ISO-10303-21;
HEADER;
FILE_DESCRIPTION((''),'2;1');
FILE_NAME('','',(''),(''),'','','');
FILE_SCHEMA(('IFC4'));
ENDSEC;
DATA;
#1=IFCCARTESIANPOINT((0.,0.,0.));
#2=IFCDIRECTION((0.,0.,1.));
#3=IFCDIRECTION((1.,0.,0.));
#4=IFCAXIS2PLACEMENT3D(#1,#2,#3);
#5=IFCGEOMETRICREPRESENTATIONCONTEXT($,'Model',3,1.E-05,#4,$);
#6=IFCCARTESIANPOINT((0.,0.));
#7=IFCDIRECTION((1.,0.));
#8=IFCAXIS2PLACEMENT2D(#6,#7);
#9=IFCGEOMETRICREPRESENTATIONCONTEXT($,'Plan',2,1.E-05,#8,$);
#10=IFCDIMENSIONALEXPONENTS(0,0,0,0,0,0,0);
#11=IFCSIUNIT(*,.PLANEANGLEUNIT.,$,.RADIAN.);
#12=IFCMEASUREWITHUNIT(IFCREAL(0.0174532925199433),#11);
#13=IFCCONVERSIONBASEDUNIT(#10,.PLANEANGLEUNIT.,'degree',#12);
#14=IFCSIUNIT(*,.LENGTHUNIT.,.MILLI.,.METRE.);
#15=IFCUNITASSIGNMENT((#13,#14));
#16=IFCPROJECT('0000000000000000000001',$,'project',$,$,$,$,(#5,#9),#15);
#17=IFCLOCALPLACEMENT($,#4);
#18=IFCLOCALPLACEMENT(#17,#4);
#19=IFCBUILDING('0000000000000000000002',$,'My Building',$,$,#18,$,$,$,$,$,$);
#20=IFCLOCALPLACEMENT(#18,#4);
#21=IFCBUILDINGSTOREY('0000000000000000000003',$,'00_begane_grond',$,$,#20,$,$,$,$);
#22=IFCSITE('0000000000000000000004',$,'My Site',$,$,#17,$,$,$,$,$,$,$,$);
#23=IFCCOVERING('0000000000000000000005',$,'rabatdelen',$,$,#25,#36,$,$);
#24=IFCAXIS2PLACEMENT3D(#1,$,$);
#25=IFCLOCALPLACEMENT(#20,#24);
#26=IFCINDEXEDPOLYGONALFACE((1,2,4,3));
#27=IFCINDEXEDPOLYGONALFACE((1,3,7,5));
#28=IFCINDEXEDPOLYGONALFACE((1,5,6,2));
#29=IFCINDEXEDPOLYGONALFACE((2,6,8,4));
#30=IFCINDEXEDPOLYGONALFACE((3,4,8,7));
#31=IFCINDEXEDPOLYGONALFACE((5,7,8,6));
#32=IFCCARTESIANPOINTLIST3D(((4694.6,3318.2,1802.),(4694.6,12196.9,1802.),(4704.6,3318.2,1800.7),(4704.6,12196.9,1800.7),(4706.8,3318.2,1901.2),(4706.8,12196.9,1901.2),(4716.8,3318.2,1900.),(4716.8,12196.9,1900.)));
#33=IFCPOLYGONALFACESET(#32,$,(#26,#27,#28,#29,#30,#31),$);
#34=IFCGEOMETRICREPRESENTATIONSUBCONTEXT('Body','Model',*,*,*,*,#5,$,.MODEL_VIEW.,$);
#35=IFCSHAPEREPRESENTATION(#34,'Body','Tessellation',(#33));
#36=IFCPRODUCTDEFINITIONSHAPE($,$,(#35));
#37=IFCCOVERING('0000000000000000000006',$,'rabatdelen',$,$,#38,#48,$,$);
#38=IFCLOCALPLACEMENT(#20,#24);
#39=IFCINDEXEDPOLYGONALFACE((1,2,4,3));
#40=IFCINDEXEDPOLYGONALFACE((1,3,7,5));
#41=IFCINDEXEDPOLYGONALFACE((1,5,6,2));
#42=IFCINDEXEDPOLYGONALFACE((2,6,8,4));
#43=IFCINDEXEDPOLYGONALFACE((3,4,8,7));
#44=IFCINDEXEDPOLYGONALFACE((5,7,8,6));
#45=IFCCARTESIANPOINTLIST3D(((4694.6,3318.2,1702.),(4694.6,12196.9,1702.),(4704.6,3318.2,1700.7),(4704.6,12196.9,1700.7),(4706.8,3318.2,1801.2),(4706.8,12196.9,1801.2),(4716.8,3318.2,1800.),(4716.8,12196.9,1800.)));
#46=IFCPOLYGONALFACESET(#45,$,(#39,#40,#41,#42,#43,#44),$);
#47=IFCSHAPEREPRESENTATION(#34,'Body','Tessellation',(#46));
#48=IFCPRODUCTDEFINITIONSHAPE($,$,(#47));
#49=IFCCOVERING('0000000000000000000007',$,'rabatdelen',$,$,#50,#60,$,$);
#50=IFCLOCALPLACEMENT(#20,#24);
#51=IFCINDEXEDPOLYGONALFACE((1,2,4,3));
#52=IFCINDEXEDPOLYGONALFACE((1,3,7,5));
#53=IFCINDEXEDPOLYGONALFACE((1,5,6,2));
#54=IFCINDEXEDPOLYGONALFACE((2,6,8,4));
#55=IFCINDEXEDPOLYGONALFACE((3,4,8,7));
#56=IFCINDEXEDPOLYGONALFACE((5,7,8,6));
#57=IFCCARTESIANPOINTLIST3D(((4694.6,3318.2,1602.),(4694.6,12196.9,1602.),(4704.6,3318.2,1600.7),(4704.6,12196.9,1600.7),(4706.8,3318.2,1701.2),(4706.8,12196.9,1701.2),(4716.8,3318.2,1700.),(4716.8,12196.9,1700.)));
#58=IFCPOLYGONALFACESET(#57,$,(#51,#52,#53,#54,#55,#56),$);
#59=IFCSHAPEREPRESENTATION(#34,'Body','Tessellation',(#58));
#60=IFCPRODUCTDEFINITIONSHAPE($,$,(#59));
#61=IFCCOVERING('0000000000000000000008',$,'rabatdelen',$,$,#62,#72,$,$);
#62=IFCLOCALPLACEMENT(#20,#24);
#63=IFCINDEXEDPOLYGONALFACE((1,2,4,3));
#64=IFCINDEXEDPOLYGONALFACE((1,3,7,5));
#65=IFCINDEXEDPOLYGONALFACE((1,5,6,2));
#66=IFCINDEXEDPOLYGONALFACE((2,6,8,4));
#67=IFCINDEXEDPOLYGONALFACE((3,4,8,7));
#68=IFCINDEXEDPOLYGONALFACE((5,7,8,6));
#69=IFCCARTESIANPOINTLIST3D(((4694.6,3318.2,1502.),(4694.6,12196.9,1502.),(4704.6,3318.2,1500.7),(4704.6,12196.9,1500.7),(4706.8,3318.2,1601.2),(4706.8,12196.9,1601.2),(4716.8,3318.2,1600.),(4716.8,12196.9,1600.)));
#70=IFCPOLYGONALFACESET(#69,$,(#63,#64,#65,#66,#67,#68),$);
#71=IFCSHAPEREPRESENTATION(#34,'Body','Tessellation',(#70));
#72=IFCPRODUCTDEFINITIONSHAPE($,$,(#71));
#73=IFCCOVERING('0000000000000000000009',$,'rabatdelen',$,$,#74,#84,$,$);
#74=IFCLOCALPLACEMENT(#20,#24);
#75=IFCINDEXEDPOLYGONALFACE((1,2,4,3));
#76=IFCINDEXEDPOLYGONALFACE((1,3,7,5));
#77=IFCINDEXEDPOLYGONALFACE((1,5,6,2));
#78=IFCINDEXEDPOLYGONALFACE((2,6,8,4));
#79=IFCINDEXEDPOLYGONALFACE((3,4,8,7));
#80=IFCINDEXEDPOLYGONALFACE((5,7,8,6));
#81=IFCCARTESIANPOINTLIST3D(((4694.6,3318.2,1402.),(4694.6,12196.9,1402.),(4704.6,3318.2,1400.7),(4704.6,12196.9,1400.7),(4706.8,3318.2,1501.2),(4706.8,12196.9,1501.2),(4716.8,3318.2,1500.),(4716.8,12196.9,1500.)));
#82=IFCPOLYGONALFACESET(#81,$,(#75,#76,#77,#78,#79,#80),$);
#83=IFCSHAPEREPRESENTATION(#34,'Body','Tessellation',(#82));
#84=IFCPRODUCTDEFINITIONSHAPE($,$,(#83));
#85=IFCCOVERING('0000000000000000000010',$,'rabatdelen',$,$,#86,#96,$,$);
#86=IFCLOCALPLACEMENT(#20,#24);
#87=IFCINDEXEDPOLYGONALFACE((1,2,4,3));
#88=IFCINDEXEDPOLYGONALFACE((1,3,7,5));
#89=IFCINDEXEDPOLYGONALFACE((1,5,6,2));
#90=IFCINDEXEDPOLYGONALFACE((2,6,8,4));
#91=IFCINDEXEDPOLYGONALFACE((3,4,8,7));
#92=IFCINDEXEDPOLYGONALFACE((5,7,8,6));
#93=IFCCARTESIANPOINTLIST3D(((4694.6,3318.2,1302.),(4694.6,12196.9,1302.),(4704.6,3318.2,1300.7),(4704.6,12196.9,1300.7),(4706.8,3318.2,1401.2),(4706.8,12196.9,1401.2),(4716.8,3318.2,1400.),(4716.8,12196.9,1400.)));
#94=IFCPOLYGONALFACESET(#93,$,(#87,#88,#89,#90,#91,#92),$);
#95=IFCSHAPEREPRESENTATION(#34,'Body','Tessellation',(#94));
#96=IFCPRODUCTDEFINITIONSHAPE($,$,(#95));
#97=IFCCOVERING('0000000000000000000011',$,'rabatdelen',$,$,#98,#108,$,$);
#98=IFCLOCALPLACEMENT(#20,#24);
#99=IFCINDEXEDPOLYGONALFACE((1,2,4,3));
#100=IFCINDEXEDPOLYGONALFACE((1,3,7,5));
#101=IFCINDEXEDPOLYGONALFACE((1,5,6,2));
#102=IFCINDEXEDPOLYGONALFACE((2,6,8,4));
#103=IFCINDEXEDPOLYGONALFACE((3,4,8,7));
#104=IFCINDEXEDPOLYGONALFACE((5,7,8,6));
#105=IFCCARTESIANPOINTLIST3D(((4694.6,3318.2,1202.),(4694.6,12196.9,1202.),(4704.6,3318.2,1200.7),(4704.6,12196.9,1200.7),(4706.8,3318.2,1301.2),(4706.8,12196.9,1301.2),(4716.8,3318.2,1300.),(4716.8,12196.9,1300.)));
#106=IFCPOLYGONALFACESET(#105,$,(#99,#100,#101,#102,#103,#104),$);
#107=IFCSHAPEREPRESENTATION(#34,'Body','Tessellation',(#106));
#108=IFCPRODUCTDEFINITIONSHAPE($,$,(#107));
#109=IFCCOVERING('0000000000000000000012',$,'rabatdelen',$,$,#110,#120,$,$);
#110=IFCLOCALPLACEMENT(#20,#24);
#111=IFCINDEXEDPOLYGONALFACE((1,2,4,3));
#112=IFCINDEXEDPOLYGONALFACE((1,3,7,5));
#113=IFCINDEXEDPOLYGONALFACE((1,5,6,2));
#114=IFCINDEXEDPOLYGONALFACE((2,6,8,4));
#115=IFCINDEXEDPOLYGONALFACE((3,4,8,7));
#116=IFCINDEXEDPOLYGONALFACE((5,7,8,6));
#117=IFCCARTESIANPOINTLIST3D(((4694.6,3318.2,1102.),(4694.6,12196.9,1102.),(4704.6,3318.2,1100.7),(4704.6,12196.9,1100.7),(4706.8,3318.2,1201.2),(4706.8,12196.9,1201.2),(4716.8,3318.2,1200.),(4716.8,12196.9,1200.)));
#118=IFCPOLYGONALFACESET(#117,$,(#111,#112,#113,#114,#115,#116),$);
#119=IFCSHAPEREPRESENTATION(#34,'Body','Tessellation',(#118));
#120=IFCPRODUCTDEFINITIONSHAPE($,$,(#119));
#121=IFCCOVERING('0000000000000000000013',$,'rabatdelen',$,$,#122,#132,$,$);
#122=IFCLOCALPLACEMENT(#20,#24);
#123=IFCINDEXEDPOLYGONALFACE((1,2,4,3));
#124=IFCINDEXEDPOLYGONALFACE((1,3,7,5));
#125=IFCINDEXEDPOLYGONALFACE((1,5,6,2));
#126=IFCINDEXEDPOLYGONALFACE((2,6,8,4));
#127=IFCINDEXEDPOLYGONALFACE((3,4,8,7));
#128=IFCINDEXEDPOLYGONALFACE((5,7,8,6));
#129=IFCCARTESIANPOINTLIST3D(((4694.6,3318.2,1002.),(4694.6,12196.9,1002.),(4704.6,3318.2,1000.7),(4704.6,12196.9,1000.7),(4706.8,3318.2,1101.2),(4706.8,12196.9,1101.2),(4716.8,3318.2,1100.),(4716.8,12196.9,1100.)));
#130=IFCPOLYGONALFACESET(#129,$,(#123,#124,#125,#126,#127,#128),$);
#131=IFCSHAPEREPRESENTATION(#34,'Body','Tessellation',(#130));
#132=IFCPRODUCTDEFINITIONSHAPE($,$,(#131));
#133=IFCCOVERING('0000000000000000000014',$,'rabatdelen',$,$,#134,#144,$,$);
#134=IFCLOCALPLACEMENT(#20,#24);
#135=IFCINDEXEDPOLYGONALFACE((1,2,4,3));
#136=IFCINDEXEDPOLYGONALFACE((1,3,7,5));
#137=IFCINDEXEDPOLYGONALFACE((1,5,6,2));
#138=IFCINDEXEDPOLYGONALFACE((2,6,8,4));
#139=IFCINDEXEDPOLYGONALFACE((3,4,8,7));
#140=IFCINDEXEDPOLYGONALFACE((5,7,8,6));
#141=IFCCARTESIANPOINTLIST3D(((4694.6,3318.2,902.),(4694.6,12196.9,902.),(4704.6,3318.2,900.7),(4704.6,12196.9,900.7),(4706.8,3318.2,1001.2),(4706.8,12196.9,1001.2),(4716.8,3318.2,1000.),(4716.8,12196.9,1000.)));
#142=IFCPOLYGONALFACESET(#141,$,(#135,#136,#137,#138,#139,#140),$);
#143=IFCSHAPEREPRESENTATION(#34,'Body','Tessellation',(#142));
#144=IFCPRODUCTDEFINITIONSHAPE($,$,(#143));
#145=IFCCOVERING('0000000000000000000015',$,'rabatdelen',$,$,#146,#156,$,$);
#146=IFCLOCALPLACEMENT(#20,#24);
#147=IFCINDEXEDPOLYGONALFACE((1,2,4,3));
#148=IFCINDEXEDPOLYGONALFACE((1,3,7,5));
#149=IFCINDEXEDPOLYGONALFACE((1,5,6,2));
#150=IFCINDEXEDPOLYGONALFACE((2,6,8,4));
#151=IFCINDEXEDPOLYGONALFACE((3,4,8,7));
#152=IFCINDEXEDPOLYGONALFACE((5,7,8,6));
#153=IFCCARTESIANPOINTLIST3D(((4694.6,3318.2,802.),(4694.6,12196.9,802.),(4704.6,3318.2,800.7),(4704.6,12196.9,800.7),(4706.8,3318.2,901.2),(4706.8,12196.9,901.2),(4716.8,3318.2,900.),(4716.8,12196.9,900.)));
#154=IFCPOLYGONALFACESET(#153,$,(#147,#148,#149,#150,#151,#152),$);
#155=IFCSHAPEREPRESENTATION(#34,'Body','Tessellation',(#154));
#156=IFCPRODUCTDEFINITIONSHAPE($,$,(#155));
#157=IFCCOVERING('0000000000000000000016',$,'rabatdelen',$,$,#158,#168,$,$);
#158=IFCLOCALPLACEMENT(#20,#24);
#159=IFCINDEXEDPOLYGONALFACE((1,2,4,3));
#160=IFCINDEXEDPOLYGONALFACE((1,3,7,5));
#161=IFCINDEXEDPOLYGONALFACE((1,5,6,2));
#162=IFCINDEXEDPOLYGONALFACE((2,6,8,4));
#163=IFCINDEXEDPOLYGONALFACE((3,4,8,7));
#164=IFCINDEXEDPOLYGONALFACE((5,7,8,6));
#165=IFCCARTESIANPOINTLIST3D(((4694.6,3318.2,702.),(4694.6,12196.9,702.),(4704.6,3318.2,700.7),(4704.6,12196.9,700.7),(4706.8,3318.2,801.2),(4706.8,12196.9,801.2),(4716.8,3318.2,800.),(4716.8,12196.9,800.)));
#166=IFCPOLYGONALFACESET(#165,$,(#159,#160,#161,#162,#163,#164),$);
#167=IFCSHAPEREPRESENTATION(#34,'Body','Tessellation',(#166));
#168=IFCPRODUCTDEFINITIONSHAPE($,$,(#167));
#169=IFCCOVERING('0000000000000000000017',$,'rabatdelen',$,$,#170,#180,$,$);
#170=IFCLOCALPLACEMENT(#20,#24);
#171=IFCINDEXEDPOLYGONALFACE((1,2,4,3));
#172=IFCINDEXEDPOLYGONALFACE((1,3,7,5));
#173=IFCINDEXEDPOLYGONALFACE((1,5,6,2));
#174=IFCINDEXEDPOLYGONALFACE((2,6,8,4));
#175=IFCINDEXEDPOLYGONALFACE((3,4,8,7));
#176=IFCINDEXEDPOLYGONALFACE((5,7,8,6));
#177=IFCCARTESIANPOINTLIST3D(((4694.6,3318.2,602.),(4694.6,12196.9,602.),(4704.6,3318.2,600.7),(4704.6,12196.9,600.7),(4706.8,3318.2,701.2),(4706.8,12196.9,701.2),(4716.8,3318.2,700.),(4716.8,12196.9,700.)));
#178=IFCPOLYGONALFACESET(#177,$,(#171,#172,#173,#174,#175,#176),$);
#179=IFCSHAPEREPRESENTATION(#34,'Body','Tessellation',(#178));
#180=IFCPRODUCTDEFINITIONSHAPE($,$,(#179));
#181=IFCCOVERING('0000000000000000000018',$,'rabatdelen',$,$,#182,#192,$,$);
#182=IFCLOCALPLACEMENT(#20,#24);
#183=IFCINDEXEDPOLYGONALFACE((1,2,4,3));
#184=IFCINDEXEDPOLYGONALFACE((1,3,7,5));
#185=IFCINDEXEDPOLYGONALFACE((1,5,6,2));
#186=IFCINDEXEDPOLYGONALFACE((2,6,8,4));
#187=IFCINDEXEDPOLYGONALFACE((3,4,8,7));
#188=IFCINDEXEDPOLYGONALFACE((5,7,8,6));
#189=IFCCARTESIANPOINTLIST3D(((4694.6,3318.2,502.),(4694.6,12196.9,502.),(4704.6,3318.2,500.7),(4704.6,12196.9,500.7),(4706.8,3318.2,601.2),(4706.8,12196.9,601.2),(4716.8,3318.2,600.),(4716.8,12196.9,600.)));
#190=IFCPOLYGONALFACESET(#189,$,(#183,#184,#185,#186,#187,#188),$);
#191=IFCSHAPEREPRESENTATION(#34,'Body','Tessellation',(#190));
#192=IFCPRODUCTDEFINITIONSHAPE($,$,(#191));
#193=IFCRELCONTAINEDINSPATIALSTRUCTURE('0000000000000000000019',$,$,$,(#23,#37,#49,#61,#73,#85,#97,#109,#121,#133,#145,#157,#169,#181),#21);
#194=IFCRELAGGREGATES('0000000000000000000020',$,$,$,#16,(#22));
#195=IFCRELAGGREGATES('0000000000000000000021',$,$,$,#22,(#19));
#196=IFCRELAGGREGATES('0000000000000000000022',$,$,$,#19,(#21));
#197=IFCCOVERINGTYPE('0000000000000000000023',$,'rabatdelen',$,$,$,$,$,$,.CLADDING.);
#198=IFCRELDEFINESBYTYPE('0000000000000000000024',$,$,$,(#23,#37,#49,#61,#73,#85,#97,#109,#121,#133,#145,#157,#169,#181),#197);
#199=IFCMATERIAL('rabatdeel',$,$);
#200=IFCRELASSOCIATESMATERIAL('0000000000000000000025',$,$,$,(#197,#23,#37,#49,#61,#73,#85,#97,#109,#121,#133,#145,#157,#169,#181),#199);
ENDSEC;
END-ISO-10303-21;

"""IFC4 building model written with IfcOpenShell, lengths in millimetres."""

from ifc_helpers import new_model, entity, si_unit, converted_unit, frame, origin_with_axes, origin_2d_with_axis, place, context, subcontext, project, spatial, rectangle, extrude, material, material_profile, profile_set, profile_usage, type_object, element, save


model = new_model("IFC4")

# Units and contexts
model_context = context("Model", 3, precision=1e-05, world=origin_with_axes())
plan_context = context("Plan", 2, precision=1e-05, world=origin_2d_with_axis())
body_context = subcontext(model_context, "Body", "Model", "MODEL_VIEW")
ifc_project = project(units=[converted_unit("PLANEANGLEUNIT", "degree", entity("IfcReal", 0.0174532925199433), si_unit("PLANEANGLEUNIT", "RADIAN"), dimensions=[0, 0, 0, 0, 0, 0, 0]), si_unit("LENGTHUNIT", "METRE", prefix="MILLI")], contexts=[model_context, plan_context])

# Site, building, storey
site_placement = place(None, origin_with_axes())
site = spatial("IfcSite", under=ifc_project, at=site_placement, Name="My Site")
building_placement = place(site_placement, origin_with_axes())
building = spatial("IfcBuilding", under=site, at=building_placement, Name="My Building")
storey_placement = place(building_placement, origin_with_axes())
storey = spatial("IfcBuildingStorey", under=building, at=storey_placement, Name="00_begane_grond")

# Coverings
ifc_material_1 = material(Name="rabatdeel")
ifc_material_profile = material_profile(ifc_material_1, rectangle(XDim=10.0, YDim=100.0))
ifc_profile_set = profile_set([ifc_material_profile])
covering_type = type_object("IfcCoveringType", Name="rabatdelen", PredefinedType="CLADDING", material=ifc_profile_set)
ifc_profile_usage_1 = profile_usage(ifc_profile_set, cardinal=7)
covering_1_placement = place(storey_placement, frame((4716.8, 12196.9, 1900.0), z_axis=(0.0, -1.0, 0.0), x_axis=(0.992546, 0.0, -0.121869)))
element("IfcCovering", 1, at=covering_1_placement, inside=storey, type_object=covering_type, material=ifc_profile_usage_1, Name="rabatdelen", context=body_context, shape_type="SweptSolid", body=[
    extrude(rectangle(XDim=10.0, YDim=100.0), frame((-5.0, -50.0, 0.0), z_axis=(0.0, 0.0, 1.0), x_axis=(1.0, 0.0, 0.0)), (0.0, 0.0, 1.0), 8878.8),
])
ifc_profile_usage_2 = profile_usage(ifc_profile_set, cardinal=7)
covering_2_placement = place(storey_placement, frame((4716.8, 12196.9, 1800.0), z_axis=(0.0, -1.0, 0.0), x_axis=(0.992546, 0.0, -0.121869)))
element("IfcCovering", 2, at=covering_2_placement, inside=storey, type_object=covering_type, material=ifc_profile_usage_2, Name="rabatdelen", context=body_context, shape_type="SweptSolid", body=[
    extrude(rectangle(XDim=10.0, YDim=100.0), frame((-5.0, -50.0, 0.0), z_axis=(0.0, 0.0, 1.0), x_axis=(1.0, 0.0, 0.0)), (0.0, 0.0, 1.0), 8878.8),
])
ifc_profile_usage_3 = profile_usage(ifc_profile_set, cardinal=7)
covering_3_placement = place(storey_placement, frame((4716.8, 12196.9, 1700.0), z_axis=(0.0, -1.0, 0.0), x_axis=(0.992546, 0.0, -0.121869)))
element("IfcCovering", 3, at=covering_3_placement, inside=storey, type_object=covering_type, material=ifc_profile_usage_3, Name="rabatdelen", context=body_context, shape_type="SweptSolid", body=[
    extrude(rectangle(XDim=10.0, YDim=100.0), frame((-5.0, -50.0, 0.0), z_axis=(0.0, 0.0, 1.0), x_axis=(1.0, 0.0, 0.0)), (0.0, 0.0, 1.0), 8878.8),
])
ifc_profile_usage_4 = profile_usage(ifc_profile_set, cardinal=7)
covering_4_placement = place(storey_placement, frame((4716.8, 12196.9, 1600.0), z_axis=(0.0, -1.0, 0.0), x_axis=(0.992546, 0.0, -0.121869)))
element("IfcCovering", 4, at=covering_4_placement, inside=storey, type_object=covering_type, material=ifc_profile_usage_4, Name="rabatdelen", context=body_context, shape_type="SweptSolid", body=[
    extrude(rectangle(XDim=10.0, YDim=100.0), frame((-5.0, -50.0, 0.0), z_axis=(0.0, 0.0, 1.0), x_axis=(1.0, 0.0, 0.0)), (0.0, 0.0, 1.0), 8878.8),
])
ifc_profile_usage_5 = profile_usage(ifc_profile_set, cardinal=7)
covering_5_placement = place(storey_placement, frame((4716.8, 12196.9, 1500.0), z_axis=(0.0, -1.0, 0.0), x_axis=(0.992546, 0.0, -0.121869)))
element("IfcCovering", 5, at=covering_5_placement, inside=storey, type_object=covering_type, material=ifc_profile_usage_5, Name="rabatdelen", context=body_context, shape_type="SweptSolid", body=[
    extrude(rectangle(XDim=10.0, YDim=100.0), frame((-5.0, -50.0, 0.0), z_axis=(0.0, 0.0, 1.0), x_axis=(1.0, 0.0, 0.0)), (0.0, 0.0, 1.0), 8878.8),
])
ifc_profile_usage_6 = profile_usage(ifc_profile_set, cardinal=7)
covering_6_placement = place(storey_placement, frame((4716.8, 12196.9, 1400.0), z_axis=(0.0, -1.0, 0.0), x_axis=(0.992546, 0.0, -0.121869)))
element("IfcCovering", 6, at=covering_6_placement, inside=storey, type_object=covering_type, material=ifc_profile_usage_6, Name="rabatdelen", context=body_context, shape_type="SweptSolid", body=[
    extrude(rectangle(XDim=10.0, YDim=100.0), frame((-5.0, -50.0, 0.0), z_axis=(0.0, 0.0, 1.0), x_axis=(1.0, 0.0, 0.0)), (0.0, 0.0, 1.0), 8878.8),
])
ifc_profile_usage_7 = profile_usage(ifc_profile_set, cardinal=7)
covering_7_placement = place(storey_placement, frame((4716.8, 12196.9, 1300.0), z_axis=(0.0, -1.0, 0.0), x_axis=(0.992546, 0.0, -0.121869)))
element("IfcCovering", 7, at=covering_7_placement, inside=storey, type_object=covering_type, material=ifc_profile_usage_7, Name="rabatdelen", context=body_context, shape_type="SweptSolid", body=[
    extrude(rectangle(XDim=10.0, YDim=100.0), frame((-5.0, -50.0, 0.0), z_axis=(0.0, 0.0, 1.0), x_axis=(1.0, 0.0, 0.0)), (0.0, 0.0, 1.0), 8878.8),
])
ifc_profile_usage_8 = profile_usage(ifc_profile_set, cardinal=7)
covering_8_placement = place(storey_placement, frame((4716.8, 12196.9, 1200.0), z_axis=(0.0, -1.0, 0.0), x_axis=(0.992546, 0.0, -0.121869)))
element("IfcCovering", 8, at=covering_8_placement, inside=storey, type_object=covering_type, material=ifc_profile_usage_8, Name="rabatdelen", context=body_context, shape_type="SweptSolid", body=[
    extrude(rectangle(XDim=10.0, YDim=100.0), frame((-5.0, -50.0, 0.0), z_axis=(0.0, 0.0, 1.0), x_axis=(1.0, 0.0, 0.0)), (0.0, 0.0, 1.0), 8878.8),
])
ifc_profile_usage_9 = profile_usage(ifc_profile_set, cardinal=7)
covering_9_placement = place(storey_placement, frame((4716.8, 12196.9, 1100.0), z_axis=(0.0, -1.0, 0.0), x_axis=(0.992546, 0.0, -0.121869)))
element("IfcCovering", 9, at=covering_9_placement, inside=storey, type_object=covering_type, material=ifc_profile_usage_9, Name="rabatdelen", context=body_context, shape_type="SweptSolid", body=[
    extrude(rectangle(XDim=10.0, YDim=100.0), frame((-5.0, -50.0, 0.0), z_axis=(0.0, 0.0, 1.0), x_axis=(1.0, 0.0, 0.0)), (0.0, 0.0, 1.0), 8878.8),
])
ifc_profile_usage_10 = profile_usage(ifc_profile_set, cardinal=7)
covering_10_placement = place(storey_placement, frame((4716.8, 12196.9, 1000.0), z_axis=(0.0, -1.0, 0.0), x_axis=(0.992546, 0.0, -0.121869)))
element("IfcCovering", 10, at=covering_10_placement, inside=storey, type_object=covering_type, material=ifc_profile_usage_10, Name="rabatdelen", context=body_context, shape_type="SweptSolid", body=[
    extrude(rectangle(XDim=10.0, YDim=100.0), frame((-5.0, -50.0, 0.0), z_axis=(0.0, 0.0, 1.0), x_axis=(1.0, 0.0, 0.0)), (0.0, 0.0, 1.0), 8878.8),
])
ifc_profile_usage_11 = profile_usage(ifc_profile_set, cardinal=7)
covering_11_placement = place(storey_placement, frame((4716.8, 12196.9, 900.0), z_axis=(0.0, -1.0, 0.0), x_axis=(0.992546, 0.0, -0.121869)))
element("IfcCovering", 11, at=covering_11_placement, inside=storey, type_object=covering_type, material=ifc_profile_usage_11, Name="rabatdelen", context=body_context, shape_type="SweptSolid", body=[
    extrude(rectangle(XDim=10.0, YDim=100.0), frame((-5.0, -50.0, 0.0), z_axis=(0.0, 0.0, 1.0), x_axis=(1.0, 0.0, 0.0)), (0.0, 0.0, 1.0), 8878.8),
])
ifc_profile_usage_12 = profile_usage(ifc_profile_set, cardinal=7)
covering_12_placement = place(storey_placement, frame((4716.8, 12196.9, 800.0), z_axis=(0.0, -1.0, 0.0), x_axis=(0.992546, 0.0, -0.121869)))
element("IfcCovering", 12, at=covering_12_placement, inside=storey, type_object=covering_type, material=ifc_profile_usage_12, Name="rabatdelen", context=body_context, shape_type="SweptSolid", body=[
    extrude(rectangle(XDim=10.0, YDim=100.0), frame((-5.0, -50.0, 0.0), z_axis=(0.0, 0.0, 1.0), x_axis=(1.0, 0.0, 0.0)), (0.0, 0.0, 1.0), 8878.8),
])
ifc_profile_usage_13 = profile_usage(ifc_profile_set, cardinal=7)
covering_13_placement = place(storey_placement, frame((4716.8, 12196.9, 700.0), z_axis=(0.0, -1.0, 0.0), x_axis=(0.992546, 0.0, -0.121869)))
element("IfcCovering", 13, at=covering_13_placement, inside=storey, type_object=covering_type, material=ifc_profile_usage_13, Name="rabatdelen", context=body_context, shape_type="SweptSolid", body=[
    extrude(rectangle(XDim=10.0, YDim=100.0), frame((-5.0, -50.0, 0.0), z_axis=(0.0, 0.0, 1.0), x_axis=(1.0, 0.0, 0.0)), (0.0, 0.0, 1.0), 8878.8),
])
ifc_profile_usage_14 = profile_usage(ifc_profile_set, cardinal=7)
covering_14_placement = place(storey_placement, frame((4716.8, 12196.9, 600.0), z_axis=(0.0, -1.0, 0.0), x_axis=(0.992546, 0.0, -0.121869)))
element("IfcCovering", 14, at=covering_14_placement, inside=storey, type_object=covering_type, material=ifc_profile_usage_14, Name="rabatdelen", context=body_context, shape_type="SweptSolid", body=[
    extrude(rectangle(XDim=10.0, YDim=100.0), frame((-5.0, -50.0, 0.0), z_axis=(0.0, 0.0, 1.0), x_axis=(1.0, 0.0, 0.0)), (0.0, 0.0, 1.0), 8878.8),
])

save(model, "model.ifc")
